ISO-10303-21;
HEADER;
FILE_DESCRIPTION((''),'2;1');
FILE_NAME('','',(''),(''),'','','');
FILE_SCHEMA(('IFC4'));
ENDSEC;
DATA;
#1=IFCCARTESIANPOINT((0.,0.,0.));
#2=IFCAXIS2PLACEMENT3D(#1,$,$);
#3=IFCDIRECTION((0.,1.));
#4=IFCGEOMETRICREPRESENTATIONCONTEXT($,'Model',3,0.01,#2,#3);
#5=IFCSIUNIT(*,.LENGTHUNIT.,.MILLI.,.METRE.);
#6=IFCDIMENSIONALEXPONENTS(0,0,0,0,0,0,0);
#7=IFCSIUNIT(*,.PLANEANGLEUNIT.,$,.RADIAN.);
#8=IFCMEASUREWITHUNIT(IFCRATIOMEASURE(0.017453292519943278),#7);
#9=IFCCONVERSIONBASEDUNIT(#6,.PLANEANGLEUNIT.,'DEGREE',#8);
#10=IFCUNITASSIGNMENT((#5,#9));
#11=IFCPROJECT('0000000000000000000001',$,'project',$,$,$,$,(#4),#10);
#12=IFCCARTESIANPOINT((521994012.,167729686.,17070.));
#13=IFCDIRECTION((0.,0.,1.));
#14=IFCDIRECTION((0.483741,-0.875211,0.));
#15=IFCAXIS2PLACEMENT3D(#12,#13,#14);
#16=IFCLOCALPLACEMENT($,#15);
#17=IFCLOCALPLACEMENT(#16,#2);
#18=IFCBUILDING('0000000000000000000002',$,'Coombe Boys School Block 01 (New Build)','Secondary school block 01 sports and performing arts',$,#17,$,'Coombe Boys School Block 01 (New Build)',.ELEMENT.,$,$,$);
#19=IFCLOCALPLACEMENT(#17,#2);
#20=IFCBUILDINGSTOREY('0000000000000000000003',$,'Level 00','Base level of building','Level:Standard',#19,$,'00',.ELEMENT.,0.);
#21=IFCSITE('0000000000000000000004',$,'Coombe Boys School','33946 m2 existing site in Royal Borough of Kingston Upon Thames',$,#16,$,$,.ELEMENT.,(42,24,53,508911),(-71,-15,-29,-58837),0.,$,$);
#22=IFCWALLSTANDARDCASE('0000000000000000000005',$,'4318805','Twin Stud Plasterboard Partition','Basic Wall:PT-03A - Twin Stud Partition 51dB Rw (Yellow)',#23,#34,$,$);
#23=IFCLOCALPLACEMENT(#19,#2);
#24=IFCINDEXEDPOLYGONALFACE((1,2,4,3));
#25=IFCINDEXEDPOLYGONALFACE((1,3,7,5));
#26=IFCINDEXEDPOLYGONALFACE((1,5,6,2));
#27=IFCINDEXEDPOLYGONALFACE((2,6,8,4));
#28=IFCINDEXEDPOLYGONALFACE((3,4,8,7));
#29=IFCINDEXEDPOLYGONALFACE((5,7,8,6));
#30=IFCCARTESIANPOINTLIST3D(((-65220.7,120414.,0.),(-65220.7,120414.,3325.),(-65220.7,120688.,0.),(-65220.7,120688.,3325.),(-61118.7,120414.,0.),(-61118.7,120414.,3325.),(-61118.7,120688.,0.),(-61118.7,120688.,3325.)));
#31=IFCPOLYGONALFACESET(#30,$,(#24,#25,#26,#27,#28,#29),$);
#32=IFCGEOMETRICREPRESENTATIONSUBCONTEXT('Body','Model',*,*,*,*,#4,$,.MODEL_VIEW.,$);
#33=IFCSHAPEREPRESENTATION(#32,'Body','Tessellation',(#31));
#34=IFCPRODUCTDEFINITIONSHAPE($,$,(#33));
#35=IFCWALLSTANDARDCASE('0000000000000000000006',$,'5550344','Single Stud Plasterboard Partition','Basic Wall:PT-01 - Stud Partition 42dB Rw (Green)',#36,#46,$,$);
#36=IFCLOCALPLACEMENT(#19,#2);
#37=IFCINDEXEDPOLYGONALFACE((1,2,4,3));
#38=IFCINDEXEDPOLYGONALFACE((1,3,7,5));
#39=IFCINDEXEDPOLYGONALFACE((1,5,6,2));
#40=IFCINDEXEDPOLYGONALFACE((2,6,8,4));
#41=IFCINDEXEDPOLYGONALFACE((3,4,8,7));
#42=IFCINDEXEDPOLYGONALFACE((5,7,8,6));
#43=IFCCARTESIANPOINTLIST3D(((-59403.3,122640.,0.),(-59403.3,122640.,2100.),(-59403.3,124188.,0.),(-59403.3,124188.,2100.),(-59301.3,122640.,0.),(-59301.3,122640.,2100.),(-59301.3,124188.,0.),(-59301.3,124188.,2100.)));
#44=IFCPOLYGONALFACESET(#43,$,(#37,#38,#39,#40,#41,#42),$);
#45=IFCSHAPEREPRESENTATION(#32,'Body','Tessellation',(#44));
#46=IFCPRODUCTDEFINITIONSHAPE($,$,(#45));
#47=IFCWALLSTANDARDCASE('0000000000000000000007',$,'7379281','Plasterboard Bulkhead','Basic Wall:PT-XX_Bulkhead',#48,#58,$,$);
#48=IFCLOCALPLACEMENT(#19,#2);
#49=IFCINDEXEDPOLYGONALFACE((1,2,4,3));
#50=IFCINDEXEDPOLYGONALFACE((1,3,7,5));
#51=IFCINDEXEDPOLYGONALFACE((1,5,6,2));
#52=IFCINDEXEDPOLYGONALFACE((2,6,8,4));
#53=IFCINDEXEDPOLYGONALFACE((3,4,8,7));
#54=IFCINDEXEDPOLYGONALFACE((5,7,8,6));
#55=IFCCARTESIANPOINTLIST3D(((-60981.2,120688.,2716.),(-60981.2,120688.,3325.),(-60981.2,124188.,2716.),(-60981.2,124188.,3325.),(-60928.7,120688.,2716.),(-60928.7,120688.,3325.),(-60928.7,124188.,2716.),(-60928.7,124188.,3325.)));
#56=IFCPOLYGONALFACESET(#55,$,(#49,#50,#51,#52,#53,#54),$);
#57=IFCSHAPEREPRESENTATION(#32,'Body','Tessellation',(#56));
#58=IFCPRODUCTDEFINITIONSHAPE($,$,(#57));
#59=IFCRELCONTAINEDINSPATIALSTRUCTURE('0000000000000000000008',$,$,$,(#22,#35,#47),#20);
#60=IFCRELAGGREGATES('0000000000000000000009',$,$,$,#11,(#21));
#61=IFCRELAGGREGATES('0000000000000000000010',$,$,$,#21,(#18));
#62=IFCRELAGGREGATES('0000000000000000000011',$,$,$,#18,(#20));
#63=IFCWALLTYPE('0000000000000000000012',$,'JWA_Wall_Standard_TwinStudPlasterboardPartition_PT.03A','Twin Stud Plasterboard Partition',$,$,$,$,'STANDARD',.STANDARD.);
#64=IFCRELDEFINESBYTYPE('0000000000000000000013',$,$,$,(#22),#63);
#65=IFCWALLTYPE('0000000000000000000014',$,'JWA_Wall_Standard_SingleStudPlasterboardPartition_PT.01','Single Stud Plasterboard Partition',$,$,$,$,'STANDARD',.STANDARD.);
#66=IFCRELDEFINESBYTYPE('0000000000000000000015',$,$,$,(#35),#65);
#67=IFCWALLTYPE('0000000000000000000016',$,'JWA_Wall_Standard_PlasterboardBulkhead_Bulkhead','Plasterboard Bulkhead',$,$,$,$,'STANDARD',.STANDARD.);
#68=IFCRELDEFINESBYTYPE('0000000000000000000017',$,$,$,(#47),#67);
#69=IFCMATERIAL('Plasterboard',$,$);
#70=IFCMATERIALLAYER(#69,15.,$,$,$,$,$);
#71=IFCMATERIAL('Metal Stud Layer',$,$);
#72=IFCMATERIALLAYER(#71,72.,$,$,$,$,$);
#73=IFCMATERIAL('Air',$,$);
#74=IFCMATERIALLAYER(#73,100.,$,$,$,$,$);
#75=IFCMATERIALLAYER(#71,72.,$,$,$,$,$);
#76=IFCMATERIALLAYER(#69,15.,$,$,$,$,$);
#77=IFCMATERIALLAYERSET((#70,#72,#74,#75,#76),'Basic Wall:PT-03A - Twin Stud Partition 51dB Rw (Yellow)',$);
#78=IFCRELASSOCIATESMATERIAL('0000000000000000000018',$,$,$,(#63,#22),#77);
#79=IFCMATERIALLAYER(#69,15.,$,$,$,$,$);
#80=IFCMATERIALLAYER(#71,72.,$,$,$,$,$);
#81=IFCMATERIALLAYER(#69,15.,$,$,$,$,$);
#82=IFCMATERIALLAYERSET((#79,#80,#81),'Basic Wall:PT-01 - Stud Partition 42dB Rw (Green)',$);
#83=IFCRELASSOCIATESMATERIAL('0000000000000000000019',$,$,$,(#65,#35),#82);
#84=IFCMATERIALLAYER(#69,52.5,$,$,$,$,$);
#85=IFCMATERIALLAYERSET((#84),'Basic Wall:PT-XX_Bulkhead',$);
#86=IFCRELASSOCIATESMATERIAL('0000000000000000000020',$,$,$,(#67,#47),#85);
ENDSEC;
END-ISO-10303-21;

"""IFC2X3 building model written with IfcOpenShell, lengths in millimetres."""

from ifc_helpers import new_model, entity, si_unit, converted_unit, direction, frame, frame_2d, origin, place, context, subcontext, project, spatial, rectangle, extrude, material, layer, layer_set, layer_usage, type_object, element, save


model = new_model("IFC2X3")

# Units and contexts
model_context = context("Model", 3, precision=0.01, world=origin(), true_north=direction((0.0, 1.0)))
body_context = subcontext(model_context, "Body", "Model", "MODEL_VIEW")
ifc_project = project(units=[si_unit("LENGTHUNIT", "METRE", prefix="MILLI"), converted_unit("PLANEANGLEUNIT", "DEGREE", entity("IfcRatioMeasure", 0.017453292519943278), si_unit("PLANEANGLEUNIT", "RADIAN"), dimensions=[0, 0, 0, 0, 0, 0, 0])], contexts=[model_context])

# Site, building, storey
site_placement = place(None, frame((521994012.0, 167729686.0, 17070.0), z_axis=(0.0, 0.0, 1.0), x_axis=(0.483741, -0.875211, 0.0)))
site = spatial("IfcSite", under=ifc_project, at=site_placement, Name="Coombe Boys School", Description="33946 m2 existing site in Royal Borough of Kingston Upon Thames", CompositionType="ELEMENT", RefLatitude=(42, 24, 53, 508911), RefLongitude=(-71, -15, -29, -58837), RefElevation=0.0)
building_placement = place(site_placement, origin())
building = spatial("IfcBuilding", under=site, at=building_placement, Name="Coombe Boys School Block 01 (New Build)", Description="Secondary school block 01 sports and performing arts", LongName="Coombe Boys School Block 01 (New Build)", CompositionType="ELEMENT")
storey_placement = place(building_placement, origin())
storey = spatial("IfcBuildingStorey", under=building, at=storey_placement, Name="Level 00", Description="Base level of building", ObjectType="Level:Standard", LongName="00", CompositionType="ELEMENT", Elevation=0.0)

# Walls
ifc_material_1 = material(Name="Plasterboard")
ifc_layer_1 = layer(ifc_material_1, 15.0)
ifc_material_2 = material(Name="Metal Stud Layer")
ifc_layer_2 = layer(ifc_material_2, 72.0)
ifc_material_3 = material(Name="Air")
ifc_layer_3 = layer(ifc_material_3, 100.0)
ifc_layer_4 = layer(ifc_material_2, 72.0)
ifc_layer_5 = layer(ifc_material_1, 15.0)
ifc_layer_set_1 = layer_set([ifc_layer_1, ifc_layer_2, ifc_layer_3, ifc_layer_4, ifc_layer_5], Name="Basic Wall:PT-03A - Twin Stud Partition 51dB Rw (Yellow)")
ifc_layer_usage_1 = layer_usage(ifc_layer_set_1, "AXIS2", "POSITIVE", -137.0)
wall_type_1 = type_object("IfcWallType", Name="JWA_Wall_Standard_TwinStudPlasterboardPartition_PT.03A", Description="Twin Stud Plasterboard Partition", ElementType="STANDARD", PredefinedType="STANDARD", material=ifc_layer_set_1)
wall_1_placement = place(storey_placement, frame((-61118.7, 120551.0, 0.0), z_axis=(0.0, 0.0, 1.0), x_axis=(-1.0, 0.0, 0.0)))
element("IfcWallStandardCase", 1, at=wall_1_placement, inside=storey, type_object=wall_type_1, material=ifc_layer_usage_1, Name="4318805", Description="Twin Stud Plasterboard Partition", ObjectType="Basic Wall:PT-03A - Twin Stud Partition 51dB Rw (Yellow)", context=body_context, shape_type="SweptSolid", body=[
    extrude(rectangle(XDim=4102.0, YDim=274.0, at=frame_2d((2051.0, 0.0), x_axis=(-1.0, 0.0))), origin(), (0.0, 0.0, 1.0), 3325.0),
])
ifc_layer_6 = layer(ifc_material_1, 15.0)
ifc_layer_7 = layer(ifc_material_2, 72.0)
ifc_layer_8 = layer(ifc_material_1, 15.0)
ifc_layer_set_2 = layer_set([ifc_layer_6, ifc_layer_7, ifc_layer_8], Name="Basic Wall:PT-01 - Stud Partition 42dB Rw (Green)")
ifc_layer_usage_2 = layer_usage(ifc_layer_set_2, "AXIS2", "NEGATIVE", 51.0)
wall_type_2 = type_object("IfcWallType", Name="JWA_Wall_Standard_SingleStudPlasterboardPartition_PT.01", Description="Single Stud Plasterboard Partition", ElementType="STANDARD", PredefinedType="STANDARD", material=ifc_layer_set_2)
wall_2_placement = place(storey_placement, frame((-59352.3, 122640.0, 0.0), z_axis=(0.0, 0.0, 1.0), x_axis=(0.0, 1.0, 0.0)))
element("IfcWallStandardCase", 2, at=wall_2_placement, inside=storey, type_object=wall_type_2, material=ifc_layer_usage_2, Name="5550344", Description="Single Stud Plasterboard Partition", ObjectType="Basic Wall:PT-01 - Stud Partition 42dB Rw (Green)", context=body_context, shape_type="SweptSolid", body=[
    extrude(rectangle(XDim=1548.0, YDim=102.0, at=frame_2d((774.0, 0.0), x_axis=(-1.0, 0.0))), origin(), (0.0, 0.0, 1.0), 2100.0),
])
ifc_layer_9 = layer(ifc_material_1, 52.5)
ifc_layer_set_3 = layer_set([ifc_layer_9], Name="Basic Wall:PT-XX_Bulkhead")
ifc_layer_usage_3 = layer_usage(ifc_layer_set_3, "AXIS2", "NEGATIVE", 26.2)
wall_type_3 = type_object("IfcWallType", Name="JWA_Wall_Standard_PlasterboardBulkhead_Bulkhead", Description="Plasterboard Bulkhead", ElementType="STANDARD", PredefinedType="STANDARD", material=ifc_layer_set_3)
wall_3_placement = place(storey_placement, frame((-60955.0, 124188.0, 2716.0), z_axis=(0.0, 0.0, 1.0), x_axis=(0.0, -1.0, 0.0)))
element("IfcWallStandardCase", 3, at=wall_3_placement, inside=storey, type_object=wall_type_3, material=ifc_layer_usage_3, Name="7379281", Description="Plasterboard Bulkhead", ObjectType="Basic Wall:PT-XX_Bulkhead", context=body_context, shape_type="SweptSolid", body=[
    extrude(rectangle(XDim=3500.0, YDim=52.5, at=frame_2d((1750.0, 0.0), x_axis=(-1.0, 0.0))), origin(), (0.0, 0.0, 1.0), 609.0),
])

save(model, "model.ifc")
